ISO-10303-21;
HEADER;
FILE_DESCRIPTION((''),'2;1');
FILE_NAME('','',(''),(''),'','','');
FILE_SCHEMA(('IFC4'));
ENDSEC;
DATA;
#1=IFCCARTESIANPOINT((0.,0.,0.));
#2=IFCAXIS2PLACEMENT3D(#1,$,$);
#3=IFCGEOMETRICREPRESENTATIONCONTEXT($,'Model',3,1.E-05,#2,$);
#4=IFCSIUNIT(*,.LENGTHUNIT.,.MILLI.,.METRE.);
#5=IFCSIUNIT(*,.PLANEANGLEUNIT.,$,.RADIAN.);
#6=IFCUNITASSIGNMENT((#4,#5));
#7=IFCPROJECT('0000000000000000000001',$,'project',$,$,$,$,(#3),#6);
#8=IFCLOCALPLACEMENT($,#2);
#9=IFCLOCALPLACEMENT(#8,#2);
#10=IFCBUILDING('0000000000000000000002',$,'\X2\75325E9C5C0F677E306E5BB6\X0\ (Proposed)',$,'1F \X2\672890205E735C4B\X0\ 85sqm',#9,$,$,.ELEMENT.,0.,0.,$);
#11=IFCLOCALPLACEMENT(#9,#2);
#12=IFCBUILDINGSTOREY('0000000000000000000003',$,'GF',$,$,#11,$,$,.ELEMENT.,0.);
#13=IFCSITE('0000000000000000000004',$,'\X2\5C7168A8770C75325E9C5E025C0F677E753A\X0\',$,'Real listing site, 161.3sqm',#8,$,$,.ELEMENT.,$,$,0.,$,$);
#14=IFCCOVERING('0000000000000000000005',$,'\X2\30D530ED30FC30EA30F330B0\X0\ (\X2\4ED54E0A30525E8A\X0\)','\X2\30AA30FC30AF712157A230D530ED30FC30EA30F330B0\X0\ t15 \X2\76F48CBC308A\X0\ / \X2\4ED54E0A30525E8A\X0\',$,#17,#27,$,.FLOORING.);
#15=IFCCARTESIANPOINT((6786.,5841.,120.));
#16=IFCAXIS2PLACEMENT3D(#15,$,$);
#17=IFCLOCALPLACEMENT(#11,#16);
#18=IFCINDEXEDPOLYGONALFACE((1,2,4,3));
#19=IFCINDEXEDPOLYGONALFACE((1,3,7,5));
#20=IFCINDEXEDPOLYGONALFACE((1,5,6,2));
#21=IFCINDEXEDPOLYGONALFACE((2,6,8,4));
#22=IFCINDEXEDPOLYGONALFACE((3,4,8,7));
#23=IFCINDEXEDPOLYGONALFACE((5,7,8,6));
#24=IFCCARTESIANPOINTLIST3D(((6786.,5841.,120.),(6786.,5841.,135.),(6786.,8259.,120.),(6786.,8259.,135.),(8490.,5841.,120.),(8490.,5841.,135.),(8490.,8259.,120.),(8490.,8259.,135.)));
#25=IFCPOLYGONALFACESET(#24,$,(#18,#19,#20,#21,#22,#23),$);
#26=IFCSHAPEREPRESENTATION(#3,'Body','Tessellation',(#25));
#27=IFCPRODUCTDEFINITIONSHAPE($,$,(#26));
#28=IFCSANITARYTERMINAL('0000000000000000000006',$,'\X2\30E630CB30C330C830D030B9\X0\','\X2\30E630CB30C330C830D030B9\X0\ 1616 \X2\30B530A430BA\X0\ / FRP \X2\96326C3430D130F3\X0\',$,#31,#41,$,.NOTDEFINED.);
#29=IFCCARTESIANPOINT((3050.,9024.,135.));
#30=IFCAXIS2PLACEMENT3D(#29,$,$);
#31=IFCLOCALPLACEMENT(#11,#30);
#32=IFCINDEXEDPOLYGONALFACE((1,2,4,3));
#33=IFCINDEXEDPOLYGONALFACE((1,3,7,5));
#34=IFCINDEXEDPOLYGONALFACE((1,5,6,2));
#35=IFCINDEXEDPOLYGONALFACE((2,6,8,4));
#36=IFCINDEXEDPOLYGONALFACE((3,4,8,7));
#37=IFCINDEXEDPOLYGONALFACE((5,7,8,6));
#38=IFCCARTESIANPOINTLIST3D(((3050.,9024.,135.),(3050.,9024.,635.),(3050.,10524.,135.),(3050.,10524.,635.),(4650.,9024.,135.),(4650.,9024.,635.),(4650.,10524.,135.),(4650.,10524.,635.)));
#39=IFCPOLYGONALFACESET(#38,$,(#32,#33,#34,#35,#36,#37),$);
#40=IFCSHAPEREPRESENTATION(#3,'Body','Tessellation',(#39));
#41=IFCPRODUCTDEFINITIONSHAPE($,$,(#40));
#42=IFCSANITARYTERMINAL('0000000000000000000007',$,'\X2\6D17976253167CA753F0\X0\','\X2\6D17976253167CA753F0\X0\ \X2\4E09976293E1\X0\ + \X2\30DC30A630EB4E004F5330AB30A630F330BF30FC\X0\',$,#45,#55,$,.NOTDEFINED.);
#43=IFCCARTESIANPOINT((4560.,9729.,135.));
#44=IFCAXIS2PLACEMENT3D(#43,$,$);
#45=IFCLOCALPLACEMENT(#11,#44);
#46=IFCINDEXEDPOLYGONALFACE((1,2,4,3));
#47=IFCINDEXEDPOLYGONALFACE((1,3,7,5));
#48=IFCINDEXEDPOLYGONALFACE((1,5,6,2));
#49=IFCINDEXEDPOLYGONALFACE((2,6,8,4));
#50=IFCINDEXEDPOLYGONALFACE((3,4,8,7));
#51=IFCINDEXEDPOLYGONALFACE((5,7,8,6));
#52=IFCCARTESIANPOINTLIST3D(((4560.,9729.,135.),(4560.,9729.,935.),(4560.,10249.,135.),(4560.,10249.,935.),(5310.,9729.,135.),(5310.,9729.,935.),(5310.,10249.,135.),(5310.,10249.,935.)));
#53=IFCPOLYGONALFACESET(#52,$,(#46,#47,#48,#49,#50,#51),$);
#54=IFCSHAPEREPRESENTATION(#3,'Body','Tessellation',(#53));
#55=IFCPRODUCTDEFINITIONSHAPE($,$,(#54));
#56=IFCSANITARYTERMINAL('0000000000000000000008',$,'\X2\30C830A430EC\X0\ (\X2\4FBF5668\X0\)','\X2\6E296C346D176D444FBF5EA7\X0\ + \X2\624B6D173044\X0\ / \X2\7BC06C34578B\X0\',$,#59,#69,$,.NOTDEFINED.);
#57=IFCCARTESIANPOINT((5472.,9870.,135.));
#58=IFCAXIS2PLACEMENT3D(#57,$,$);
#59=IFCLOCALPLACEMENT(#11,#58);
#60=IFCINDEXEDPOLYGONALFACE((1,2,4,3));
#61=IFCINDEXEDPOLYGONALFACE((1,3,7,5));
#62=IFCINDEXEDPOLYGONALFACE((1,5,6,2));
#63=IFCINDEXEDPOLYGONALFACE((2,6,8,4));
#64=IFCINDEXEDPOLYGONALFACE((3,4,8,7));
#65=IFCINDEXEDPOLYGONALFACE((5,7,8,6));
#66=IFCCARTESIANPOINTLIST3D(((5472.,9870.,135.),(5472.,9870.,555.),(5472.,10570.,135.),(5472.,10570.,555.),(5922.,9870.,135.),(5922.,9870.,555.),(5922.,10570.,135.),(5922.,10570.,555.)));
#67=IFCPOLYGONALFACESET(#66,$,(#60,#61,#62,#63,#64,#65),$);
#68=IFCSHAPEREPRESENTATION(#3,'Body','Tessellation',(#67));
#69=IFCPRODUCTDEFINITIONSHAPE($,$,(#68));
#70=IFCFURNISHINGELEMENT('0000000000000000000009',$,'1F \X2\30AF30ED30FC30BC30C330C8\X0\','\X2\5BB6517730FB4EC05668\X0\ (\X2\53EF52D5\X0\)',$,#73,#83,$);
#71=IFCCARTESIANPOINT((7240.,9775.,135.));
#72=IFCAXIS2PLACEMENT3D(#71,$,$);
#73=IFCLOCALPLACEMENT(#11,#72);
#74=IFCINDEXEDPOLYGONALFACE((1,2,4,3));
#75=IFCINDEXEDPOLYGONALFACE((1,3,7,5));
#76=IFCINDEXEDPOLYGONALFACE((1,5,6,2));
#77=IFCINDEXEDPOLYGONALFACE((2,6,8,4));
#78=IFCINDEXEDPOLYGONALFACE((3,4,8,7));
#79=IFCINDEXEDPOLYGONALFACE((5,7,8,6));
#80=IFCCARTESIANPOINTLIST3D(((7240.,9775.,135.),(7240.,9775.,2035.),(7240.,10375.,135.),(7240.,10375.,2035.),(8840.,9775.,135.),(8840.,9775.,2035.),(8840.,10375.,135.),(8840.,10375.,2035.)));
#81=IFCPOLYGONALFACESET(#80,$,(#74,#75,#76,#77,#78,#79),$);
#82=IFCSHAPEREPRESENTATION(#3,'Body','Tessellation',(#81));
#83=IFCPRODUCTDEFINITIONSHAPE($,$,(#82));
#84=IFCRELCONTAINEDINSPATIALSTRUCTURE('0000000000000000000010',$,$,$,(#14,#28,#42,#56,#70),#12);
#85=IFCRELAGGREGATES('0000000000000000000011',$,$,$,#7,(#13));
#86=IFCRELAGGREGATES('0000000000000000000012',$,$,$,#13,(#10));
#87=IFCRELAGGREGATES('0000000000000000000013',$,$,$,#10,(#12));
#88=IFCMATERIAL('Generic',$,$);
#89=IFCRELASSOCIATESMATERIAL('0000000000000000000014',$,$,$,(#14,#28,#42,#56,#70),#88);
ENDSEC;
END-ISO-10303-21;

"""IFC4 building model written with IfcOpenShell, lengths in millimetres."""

from ifc_helpers import new_model, si_unit, frame, frame_2d, origin, place, context, project, spatial, rectangle, extrude, material, element, save


model = new_model("IFC4")

# Units and contexts
model_context = context("Model", 3, precision=1e-05, world=origin())
ifc_project = project(units=[si_unit("LENGTHUNIT", "METRE", prefix="MILLI"), si_unit("PLANEANGLEUNIT", "RADIAN")], contexts=[model_context])

# Site, building, storey
site_placement = place(None, origin())
site = spatial("IfcSite", under=ifc_project, at=site_placement, Name="山梨県甲府市小松町", ObjectType="Real listing site, 161.3sqm", CompositionType="ELEMENT", RefElevation=0.0)
building_placement = place(site_placement, origin())
building = spatial("IfcBuilding", under=site, at=building_placement, Name="甲府小松の家 (Proposed)", ObjectType="1F 木造平屋 85sqm", CompositionType="ELEMENT", ElevationOfRefHeight=0.0, ElevationOfTerrain=0.0)
storey_placement = place(building_placement, origin())
storey = spatial("IfcBuildingStorey", under=building, at=storey_placement, Name="GF", CompositionType="ELEMENT", Elevation=0.0)

# Covering
ifc_material_1 = material(Name="Generic")
covering_1_placement = place(storey_placement, frame((6786.0, 5841.0, 120.0)))
element("IfcCovering", 1, at=covering_1_placement, inside=storey, material=ifc_material_1, Name="フローリング (仕上げ床)", Description="オーク無垢フローリング t15 直貼り / 仕上げ床", PredefinedType="FLOORING", context=model_context, shape_type="SweptSolid", body=[
    extrude(rectangle(XDim=1704.0, YDim=2418.0, at=frame_2d((852.0, 1209.0))), frame((6786.0, 5841.0, 120.0)), (0.0, 0.0, 1.0), 15.0),
])

# Sanitary terminals
sanitary_terminal_1_placement = place(storey_placement, frame((3050.0, 9024.0, 135.0)))
element("IfcSanitaryTerminal", 2, at=sanitary_terminal_1_placement, inside=storey, material=ifc_material_1, Name="ユニットバス", Description="ユニットバス 1616 サイズ / FRP 防水パン", PredefinedType="NOTDEFINED", context=model_context, shape_type="SweptSolid", body=[
    extrude(rectangle(XDim=1600.0, YDim=1500.0, at=frame_2d((800.0, 750.0))), frame((3050.0, 9024.0, 135.0)), (0.0, 0.0, 1.0), 500.0),
])
sanitary_terminal_2_placement = place(storey_placement, frame((4560.0, 9729.0, 135.0)))
element("IfcSanitaryTerminal", 3, at=sanitary_terminal_2_placement, inside=storey, material=ifc_material_1, Name="洗面化粧台", Description="洗面化粧台 三面鏡 + ボウル一体カウンター", PredefinedType="NOTDEFINED", context=model_context, shape_type="SweptSolid", body=[
    extrude(rectangle(XDim=750.0, YDim=520.0, at=frame_2d((375.0, 260.0))), frame((4560.0, 9729.0, 135.0)), (0.0, 0.0, 1.0), 800.0),
])
sanitary_terminal_3_placement = place(storey_placement, frame((5472.0, 9870.0, 135.0)))
element("IfcSanitaryTerminal", 4, at=sanitary_terminal_3_placement, inside=storey, material=ifc_material_1, Name="トイレ (便器)", Description="温水洗浄便座 + 手洗い / 節水型", PredefinedType="NOTDEFINED", context=model_context, shape_type="SweptSolid", body=[
    extrude(rectangle(XDim=450.0, YDim=700.0, at=frame_2d((225.0, 350.0))), frame((5472.0, 9870.0, 135.0)), (0.0, 0.0, 1.0), 420.0),
])

# Furnishing element
furnishing_placement = place(storey_placement, frame((7240.0, 9775.0, 135.0)))
element("IfcFurnishingElement", 5, at=furnishing_placement, inside=storey, material=ifc_material_1, Name="1F クローゼット", Description="家具・什器 (可動)", context=model_context, shape_type="SweptSolid", body=[
    extrude(rectangle(XDim=1600.0, YDim=600.0, at=frame_2d((800.0, 300.0))), frame((7240.0, 9775.0, 135.0)), (0.0, 0.0, 1.0), 1900.0),
])

save(model, "model.ifc")
